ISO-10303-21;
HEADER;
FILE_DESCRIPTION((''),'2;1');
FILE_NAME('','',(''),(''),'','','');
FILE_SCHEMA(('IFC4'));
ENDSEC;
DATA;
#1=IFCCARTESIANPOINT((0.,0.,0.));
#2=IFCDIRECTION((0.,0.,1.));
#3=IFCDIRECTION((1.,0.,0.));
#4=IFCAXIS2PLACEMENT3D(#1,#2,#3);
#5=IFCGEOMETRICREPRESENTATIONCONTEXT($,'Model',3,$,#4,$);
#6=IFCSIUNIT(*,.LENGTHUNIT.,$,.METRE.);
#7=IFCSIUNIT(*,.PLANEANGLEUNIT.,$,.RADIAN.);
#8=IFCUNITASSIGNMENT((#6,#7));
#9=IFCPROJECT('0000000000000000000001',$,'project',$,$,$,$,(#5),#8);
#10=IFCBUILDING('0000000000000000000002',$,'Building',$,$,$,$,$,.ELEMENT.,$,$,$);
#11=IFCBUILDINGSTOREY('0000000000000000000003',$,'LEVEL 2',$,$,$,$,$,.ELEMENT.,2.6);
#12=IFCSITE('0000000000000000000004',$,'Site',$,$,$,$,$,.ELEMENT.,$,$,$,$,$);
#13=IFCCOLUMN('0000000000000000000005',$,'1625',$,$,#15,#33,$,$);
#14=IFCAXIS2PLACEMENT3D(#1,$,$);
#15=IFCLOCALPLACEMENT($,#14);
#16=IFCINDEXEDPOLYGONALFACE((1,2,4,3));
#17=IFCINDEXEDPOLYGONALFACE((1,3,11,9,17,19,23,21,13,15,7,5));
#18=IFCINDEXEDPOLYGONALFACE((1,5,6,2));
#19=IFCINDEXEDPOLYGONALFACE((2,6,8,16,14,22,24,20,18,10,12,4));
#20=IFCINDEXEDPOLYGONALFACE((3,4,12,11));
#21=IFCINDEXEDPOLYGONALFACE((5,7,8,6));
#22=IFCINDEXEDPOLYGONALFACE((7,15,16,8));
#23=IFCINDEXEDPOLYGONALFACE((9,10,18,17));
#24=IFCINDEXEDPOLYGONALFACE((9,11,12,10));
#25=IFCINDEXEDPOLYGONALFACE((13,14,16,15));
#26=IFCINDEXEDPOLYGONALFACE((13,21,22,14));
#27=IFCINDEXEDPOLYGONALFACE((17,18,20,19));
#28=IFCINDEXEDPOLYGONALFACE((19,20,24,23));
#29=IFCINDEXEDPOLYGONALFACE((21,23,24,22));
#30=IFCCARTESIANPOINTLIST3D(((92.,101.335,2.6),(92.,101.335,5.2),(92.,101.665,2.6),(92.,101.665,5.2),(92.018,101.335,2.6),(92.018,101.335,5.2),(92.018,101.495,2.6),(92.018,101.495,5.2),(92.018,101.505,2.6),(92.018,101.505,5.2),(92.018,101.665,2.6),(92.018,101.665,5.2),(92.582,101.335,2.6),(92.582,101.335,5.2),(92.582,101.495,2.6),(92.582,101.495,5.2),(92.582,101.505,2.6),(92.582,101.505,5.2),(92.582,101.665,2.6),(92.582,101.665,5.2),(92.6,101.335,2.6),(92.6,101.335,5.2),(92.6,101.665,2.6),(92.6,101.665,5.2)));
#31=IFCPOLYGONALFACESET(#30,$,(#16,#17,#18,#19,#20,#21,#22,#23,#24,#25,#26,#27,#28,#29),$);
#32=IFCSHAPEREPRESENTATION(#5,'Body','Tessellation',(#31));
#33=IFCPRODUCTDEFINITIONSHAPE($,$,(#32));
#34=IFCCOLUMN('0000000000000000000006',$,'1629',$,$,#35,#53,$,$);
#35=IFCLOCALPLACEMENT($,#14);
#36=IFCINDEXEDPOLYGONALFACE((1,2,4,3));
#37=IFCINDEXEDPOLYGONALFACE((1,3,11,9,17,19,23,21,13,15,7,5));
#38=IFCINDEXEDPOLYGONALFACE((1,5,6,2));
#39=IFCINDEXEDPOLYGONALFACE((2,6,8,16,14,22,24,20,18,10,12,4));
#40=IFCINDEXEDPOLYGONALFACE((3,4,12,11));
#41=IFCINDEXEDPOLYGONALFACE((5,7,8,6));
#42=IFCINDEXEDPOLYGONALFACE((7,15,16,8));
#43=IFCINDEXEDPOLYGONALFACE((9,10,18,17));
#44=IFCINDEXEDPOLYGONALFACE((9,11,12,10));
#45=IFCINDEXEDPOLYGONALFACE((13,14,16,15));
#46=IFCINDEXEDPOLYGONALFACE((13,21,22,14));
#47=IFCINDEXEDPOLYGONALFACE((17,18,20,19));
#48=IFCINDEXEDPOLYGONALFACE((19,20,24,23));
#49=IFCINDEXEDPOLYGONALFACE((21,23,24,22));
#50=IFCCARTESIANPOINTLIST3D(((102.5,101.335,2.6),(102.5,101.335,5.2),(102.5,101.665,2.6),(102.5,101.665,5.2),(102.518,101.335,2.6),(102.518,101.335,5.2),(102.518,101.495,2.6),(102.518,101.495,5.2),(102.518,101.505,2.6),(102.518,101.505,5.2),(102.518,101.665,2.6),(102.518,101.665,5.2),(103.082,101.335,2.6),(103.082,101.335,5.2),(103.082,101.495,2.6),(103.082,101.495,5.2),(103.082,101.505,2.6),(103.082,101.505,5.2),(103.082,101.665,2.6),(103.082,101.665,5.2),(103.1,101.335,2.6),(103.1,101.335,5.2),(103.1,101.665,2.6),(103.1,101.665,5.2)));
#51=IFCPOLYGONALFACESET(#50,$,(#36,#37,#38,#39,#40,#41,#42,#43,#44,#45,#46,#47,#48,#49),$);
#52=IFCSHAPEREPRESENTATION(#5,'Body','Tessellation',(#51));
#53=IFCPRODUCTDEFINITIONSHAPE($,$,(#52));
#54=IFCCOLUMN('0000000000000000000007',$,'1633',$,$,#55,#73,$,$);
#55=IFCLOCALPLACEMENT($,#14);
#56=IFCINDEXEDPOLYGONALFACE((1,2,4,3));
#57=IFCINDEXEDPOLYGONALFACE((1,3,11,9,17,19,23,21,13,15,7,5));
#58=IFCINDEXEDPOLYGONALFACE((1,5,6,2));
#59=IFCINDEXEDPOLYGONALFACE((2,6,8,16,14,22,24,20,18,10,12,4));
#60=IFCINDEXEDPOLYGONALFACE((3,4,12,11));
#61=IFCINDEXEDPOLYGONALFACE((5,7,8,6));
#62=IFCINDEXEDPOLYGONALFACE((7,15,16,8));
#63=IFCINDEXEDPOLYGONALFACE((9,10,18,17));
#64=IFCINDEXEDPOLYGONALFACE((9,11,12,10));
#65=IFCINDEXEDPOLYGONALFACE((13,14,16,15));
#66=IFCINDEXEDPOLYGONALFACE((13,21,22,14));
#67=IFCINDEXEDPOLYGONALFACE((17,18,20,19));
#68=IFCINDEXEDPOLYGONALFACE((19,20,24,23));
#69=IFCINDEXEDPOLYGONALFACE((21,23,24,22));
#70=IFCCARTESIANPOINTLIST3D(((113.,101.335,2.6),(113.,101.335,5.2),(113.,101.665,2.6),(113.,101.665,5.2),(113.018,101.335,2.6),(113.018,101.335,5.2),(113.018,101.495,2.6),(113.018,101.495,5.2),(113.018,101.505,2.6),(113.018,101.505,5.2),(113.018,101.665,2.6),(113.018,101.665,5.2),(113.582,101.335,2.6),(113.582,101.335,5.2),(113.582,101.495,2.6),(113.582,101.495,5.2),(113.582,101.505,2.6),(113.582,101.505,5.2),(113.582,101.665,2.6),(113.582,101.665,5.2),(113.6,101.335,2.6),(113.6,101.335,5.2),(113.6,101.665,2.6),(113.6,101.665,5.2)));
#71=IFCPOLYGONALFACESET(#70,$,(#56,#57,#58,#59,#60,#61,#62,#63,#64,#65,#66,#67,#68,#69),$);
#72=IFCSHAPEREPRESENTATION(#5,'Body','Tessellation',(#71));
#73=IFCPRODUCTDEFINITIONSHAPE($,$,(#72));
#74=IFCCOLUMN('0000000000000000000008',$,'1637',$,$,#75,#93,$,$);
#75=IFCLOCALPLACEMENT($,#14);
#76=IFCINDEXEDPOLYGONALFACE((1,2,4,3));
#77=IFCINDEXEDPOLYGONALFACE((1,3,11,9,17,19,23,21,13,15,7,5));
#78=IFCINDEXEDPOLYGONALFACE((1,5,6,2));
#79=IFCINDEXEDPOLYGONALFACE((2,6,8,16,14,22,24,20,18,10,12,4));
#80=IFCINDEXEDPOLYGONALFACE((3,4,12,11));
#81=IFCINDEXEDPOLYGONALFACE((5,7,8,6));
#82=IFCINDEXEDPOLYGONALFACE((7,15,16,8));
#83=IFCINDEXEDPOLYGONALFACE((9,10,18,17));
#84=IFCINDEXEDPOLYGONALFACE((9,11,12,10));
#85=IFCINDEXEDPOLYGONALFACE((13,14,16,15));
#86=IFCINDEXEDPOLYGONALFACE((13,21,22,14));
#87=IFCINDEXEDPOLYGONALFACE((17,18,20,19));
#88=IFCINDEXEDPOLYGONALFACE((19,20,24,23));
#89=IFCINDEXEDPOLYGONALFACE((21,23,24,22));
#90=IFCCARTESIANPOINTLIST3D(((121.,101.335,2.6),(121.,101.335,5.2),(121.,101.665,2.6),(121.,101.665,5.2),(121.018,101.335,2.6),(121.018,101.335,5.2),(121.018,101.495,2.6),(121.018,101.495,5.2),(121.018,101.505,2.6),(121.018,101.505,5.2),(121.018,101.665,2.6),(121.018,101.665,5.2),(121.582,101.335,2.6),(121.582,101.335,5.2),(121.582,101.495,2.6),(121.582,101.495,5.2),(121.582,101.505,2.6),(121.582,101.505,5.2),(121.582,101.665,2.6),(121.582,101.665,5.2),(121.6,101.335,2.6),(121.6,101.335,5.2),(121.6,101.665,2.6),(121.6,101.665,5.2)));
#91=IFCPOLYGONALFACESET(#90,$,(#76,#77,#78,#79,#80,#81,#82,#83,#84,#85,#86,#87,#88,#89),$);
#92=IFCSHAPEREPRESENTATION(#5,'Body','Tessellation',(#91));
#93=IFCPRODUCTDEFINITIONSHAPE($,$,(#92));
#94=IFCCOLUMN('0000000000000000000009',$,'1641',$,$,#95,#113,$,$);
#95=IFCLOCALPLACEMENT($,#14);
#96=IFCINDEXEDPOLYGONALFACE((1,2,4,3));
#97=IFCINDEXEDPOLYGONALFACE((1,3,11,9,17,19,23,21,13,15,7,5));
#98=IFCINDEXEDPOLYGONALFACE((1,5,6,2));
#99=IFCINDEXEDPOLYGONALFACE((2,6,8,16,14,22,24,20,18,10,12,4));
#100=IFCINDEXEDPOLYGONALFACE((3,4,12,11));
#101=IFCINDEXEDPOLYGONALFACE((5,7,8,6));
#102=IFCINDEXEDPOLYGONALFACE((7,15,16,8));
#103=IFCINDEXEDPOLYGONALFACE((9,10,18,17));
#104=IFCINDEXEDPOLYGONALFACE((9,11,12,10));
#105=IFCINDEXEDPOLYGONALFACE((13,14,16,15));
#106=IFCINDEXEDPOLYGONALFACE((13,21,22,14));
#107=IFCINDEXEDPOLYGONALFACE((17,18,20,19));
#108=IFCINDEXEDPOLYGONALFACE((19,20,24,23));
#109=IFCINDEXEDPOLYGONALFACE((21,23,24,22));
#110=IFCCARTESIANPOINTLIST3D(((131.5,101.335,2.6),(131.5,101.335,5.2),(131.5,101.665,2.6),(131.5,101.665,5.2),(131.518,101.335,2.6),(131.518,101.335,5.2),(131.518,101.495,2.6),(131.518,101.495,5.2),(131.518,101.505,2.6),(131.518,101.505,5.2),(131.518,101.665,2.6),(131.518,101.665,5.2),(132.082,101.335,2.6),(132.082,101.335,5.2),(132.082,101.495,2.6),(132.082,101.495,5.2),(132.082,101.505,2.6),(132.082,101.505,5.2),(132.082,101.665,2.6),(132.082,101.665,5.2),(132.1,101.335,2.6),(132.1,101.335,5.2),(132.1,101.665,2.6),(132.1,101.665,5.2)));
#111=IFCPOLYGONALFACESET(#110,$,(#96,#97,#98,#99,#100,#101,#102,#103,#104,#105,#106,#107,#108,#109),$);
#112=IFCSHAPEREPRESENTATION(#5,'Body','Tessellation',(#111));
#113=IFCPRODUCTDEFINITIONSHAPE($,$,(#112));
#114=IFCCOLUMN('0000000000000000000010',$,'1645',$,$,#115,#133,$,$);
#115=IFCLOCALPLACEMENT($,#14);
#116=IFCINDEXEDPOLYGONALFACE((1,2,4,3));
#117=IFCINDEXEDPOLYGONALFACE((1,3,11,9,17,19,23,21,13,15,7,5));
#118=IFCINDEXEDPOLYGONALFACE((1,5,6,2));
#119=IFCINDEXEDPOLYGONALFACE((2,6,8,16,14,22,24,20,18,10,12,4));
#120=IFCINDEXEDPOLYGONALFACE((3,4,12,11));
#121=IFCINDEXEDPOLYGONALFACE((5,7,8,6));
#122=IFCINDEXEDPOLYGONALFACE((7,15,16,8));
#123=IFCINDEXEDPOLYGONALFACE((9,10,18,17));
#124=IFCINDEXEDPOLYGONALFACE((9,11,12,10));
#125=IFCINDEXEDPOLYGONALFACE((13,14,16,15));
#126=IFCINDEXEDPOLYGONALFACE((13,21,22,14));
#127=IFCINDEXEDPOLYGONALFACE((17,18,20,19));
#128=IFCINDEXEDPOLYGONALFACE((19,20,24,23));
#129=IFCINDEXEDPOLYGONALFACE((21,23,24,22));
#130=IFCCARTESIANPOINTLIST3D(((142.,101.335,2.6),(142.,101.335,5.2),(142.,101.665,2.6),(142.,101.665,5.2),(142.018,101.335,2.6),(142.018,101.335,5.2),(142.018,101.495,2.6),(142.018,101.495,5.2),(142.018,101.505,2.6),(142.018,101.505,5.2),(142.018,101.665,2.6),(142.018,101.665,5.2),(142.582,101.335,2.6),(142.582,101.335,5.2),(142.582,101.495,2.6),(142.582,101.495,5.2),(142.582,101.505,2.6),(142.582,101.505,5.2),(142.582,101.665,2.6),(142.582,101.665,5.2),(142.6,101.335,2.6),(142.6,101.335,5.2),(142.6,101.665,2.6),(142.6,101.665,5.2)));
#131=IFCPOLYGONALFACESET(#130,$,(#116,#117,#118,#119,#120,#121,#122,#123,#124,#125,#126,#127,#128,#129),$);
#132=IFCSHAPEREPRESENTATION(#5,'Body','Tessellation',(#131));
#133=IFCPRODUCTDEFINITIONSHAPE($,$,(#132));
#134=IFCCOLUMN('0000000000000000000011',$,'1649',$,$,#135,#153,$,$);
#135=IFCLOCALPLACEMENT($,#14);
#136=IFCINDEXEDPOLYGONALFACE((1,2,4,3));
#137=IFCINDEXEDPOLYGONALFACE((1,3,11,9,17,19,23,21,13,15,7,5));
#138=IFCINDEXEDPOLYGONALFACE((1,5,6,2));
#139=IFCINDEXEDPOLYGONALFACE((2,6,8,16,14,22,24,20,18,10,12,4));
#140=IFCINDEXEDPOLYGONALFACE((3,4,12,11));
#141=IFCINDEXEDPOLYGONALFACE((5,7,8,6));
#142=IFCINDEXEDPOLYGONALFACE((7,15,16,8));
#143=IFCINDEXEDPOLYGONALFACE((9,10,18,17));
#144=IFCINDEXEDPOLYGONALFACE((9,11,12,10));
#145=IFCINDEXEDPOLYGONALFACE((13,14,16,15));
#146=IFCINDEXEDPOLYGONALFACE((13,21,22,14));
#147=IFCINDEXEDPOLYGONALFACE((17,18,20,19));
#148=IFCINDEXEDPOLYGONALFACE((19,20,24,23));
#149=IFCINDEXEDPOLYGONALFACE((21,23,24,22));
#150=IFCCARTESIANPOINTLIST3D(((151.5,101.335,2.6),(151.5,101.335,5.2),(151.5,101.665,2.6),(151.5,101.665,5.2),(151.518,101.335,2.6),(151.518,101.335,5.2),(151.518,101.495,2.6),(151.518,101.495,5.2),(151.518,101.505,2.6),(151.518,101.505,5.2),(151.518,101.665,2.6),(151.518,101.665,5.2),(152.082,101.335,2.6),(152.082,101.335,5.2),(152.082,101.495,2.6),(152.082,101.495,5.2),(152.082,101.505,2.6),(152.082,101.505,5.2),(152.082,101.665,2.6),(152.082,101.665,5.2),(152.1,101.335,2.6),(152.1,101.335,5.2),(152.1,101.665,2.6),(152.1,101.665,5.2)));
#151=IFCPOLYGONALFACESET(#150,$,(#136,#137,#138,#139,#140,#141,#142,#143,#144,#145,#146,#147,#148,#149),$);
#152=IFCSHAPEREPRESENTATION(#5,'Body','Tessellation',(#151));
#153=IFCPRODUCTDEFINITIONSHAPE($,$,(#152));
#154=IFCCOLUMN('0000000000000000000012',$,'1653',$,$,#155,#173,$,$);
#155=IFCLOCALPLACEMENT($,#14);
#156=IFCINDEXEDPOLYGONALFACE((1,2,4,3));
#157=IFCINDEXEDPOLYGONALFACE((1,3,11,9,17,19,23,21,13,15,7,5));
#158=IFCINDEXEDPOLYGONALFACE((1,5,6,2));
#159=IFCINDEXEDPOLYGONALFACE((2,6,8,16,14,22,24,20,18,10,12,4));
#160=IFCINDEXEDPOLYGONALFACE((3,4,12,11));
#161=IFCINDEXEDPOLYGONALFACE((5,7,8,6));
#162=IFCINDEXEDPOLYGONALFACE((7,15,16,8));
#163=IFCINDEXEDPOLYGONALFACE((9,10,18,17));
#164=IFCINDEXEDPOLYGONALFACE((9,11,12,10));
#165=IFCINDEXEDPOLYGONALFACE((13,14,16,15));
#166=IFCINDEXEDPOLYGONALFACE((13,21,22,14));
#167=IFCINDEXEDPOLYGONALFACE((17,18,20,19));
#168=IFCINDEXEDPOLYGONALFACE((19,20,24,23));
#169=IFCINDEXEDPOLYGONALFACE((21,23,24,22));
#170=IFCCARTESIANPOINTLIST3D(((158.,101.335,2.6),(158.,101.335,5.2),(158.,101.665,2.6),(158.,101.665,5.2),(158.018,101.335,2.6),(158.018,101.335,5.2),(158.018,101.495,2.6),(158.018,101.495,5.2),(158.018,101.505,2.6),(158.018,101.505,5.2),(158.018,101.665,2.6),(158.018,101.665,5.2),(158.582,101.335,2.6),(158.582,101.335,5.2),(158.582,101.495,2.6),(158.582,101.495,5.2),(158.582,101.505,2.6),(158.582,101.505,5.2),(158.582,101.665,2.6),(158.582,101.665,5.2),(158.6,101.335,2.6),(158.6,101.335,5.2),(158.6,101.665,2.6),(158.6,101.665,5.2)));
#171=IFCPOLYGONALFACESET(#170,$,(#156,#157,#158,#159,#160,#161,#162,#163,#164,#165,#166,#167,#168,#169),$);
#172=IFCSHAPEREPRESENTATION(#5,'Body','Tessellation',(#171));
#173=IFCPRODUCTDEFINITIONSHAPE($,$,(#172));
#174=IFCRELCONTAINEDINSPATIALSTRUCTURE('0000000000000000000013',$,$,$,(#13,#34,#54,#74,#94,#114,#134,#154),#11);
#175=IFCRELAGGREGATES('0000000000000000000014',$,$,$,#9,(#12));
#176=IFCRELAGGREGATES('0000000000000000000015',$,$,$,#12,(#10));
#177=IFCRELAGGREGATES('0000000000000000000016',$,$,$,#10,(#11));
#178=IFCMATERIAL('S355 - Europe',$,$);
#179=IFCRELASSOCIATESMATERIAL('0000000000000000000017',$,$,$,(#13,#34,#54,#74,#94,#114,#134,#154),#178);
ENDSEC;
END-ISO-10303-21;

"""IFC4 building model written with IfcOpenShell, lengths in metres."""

from ifc_helpers import new_model, si_unit, frame, origin_with_axes, origin_2d_with_axis, place, context, project, spatial, i_section, extrude, material, material_profile, profile_set, profile_usage, element, save


model = new_model("IFC4")

# Units and contexts
model_context = context("Model", 3, world=origin_with_axes())
ifc_project = project(units=[si_unit("LENGTHUNIT", "METRE"), si_unit("PLANEANGLEUNIT", "RADIAN")], contexts=[model_context])

# Site, building, storey
site = spatial("IfcSite", under=ifc_project, Name="Site", CompositionType="ELEMENT")
building = spatial("IfcBuilding", under=site, Name="Building", CompositionType="ELEMENT")
storey = spatial("IfcBuildingStorey", under=building, Name="LEVEL 2", CompositionType="ELEMENT", Elevation=2.6)

# Columns
ifc_material = material(Name="S355 - Europe")
ifc_material_profile_1 = material_profile(ifc_material, i_section(OverallWidth=0.33, OverallDepth=0.6, WebThickness=0.01, FlangeThickness=0.018, at=origin_2d_with_axis()))
ifc_profile_set_1 = profile_set([ifc_material_profile_1])
ifc_profile_usage_1 = profile_usage(ifc_profile_set_1, cardinal=10)
column_1_placement = place(None, frame((92.3, 101.5, 2.6), z_axis=(0.0, 0.0, 1.0), x_axis=(0.0, -1.0, 0.0)))
element("IfcColumn", 1, at=column_1_placement, inside=storey, material=ifc_profile_usage_1, Name="1625", context=model_context, shape_type="SweptSolid", body=[
    extrude(i_section(OverallWidth=0.33, OverallDepth=0.6, WebThickness=0.01, FlangeThickness=0.018, at=origin_2d_with_axis()), origin_with_axes(), (0.0, 0.0, 1.0), 2.6),
])
ifc_material_profile_2 = material_profile(ifc_material, i_section(OverallWidth=0.33, OverallDepth=0.6, WebThickness=0.01, FlangeThickness=0.018, at=origin_2d_with_axis()))
ifc_profile_set_2 = profile_set([ifc_material_profile_2])
ifc_profile_usage_2 = profile_usage(ifc_profile_set_2, cardinal=10)
column_2_placement = place(None, frame((102.8, 101.5, 2.6), z_axis=(0.0, 0.0, 1.0), x_axis=(0.0, -1.0, 0.0)))
element("IfcColumn", 2, at=column_2_placement, inside=storey, material=ifc_profile_usage_2, Name="1629", context=model_context, shape_type="SweptSolid", body=[
    extrude(i_section(OverallWidth=0.33, OverallDepth=0.6, WebThickness=0.01, FlangeThickness=0.018, at=origin_2d_with_axis()), origin_with_axes(), (0.0, 0.0, 1.0), 2.6),
])
ifc_material_profile_3 = material_profile(ifc_material, i_section(OverallWidth=0.33, OverallDepth=0.6, WebThickness=0.01, FlangeThickness=0.018, at=origin_2d_with_axis()))
ifc_profile_set_3 = profile_set([ifc_material_profile_3])
ifc_profile_usage_3 = profile_usage(ifc_profile_set_3, cardinal=10)
column_3_placement = place(None, frame((113.3, 101.5, 2.6), z_axis=(0.0, 0.0, 1.0), x_axis=(0.0, -1.0, 0.0)))
element("IfcColumn", 3, at=column_3_placement, inside=storey, material=ifc_profile_usage_3, Name="1633", context=model_context, shape_type="SweptSolid", body=[
    extrude(i_section(OverallWidth=0.33, OverallDepth=0.6, WebThickness=0.01, FlangeThickness=0.018, at=origin_2d_with_axis()), origin_with_axes(), (0.0, 0.0, 1.0), 2.6),
])
ifc_material_profile_4 = material_profile(ifc_material, i_section(OverallWidth=0.33, OverallDepth=0.6, WebThickness=0.01, FlangeThickness=0.018, at=origin_2d_with_axis()))
ifc_profile_set_4 = profile_set([ifc_material_profile_4])
ifc_profile_usage_4 = profile_usage(ifc_profile_set_4, cardinal=10)
column_4_placement = place(None, frame((121.3, 101.5, 2.6), z_axis=(0.0, 0.0, 1.0), x_axis=(0.0, -1.0, 0.0)))
element("IfcColumn", 4, at=column_4_placement, inside=storey, material=ifc_profile_usage_4, Name="1637", context=model_context, shape_type="SweptSolid", body=[
    extrude(i_section(OverallWidth=0.33, OverallDepth=0.6, WebThickness=0.01, FlangeThickness=0.018, at=origin_2d_with_axis()), origin_with_axes(), (0.0, 0.0, 1.0), 2.6),
])
ifc_material_profile_5 = material_profile(ifc_material, i_section(OverallWidth=0.33, OverallDepth=0.6, WebThickness=0.01, FlangeThickness=0.018, at=origin_2d_with_axis()))
ifc_profile_set_5 = profile_set([ifc_material_profile_5])
ifc_profile_usage_5 = profile_usage(ifc_profile_set_5, cardinal=10)
column_5_placement = place(None, frame((131.8, 101.5, 2.6), z_axis=(0.0, 0.0, 1.0), x_axis=(0.0, -1.0, 0.0)))
element("IfcColumn", 5, at=column_5_placement, inside=storey, material=ifc_profile_usage_5, Name="1641", context=model_context, shape_type="SweptSolid", body=[
    extrude(i_section(OverallWidth=0.33, OverallDepth=0.6, WebThickness=0.01, FlangeThickness=0.018, at=origin_2d_with_axis()), origin_with_axes(), (0.0, 0.0, 1.0), 2.6),
])
ifc_material_profile_6 = material_profile(ifc_material, i_section(OverallWidth=0.33, OverallDepth=0.6, WebThickness=0.01, FlangeThickness=0.018, at=origin_2d_with_axis()))
ifc_profile_set_6 = profile_set([ifc_material_profile_6])
ifc_profile_usage_6 = profile_usage(ifc_profile_set_6, cardinal=10)
column_6_placement = place(None, frame((142.3, 101.5, 2.6), z_axis=(0.0, 0.0, 1.0), x_axis=(0.0, -1.0, 0.0)))
element("IfcColumn", 6, at=column_6_placement, inside=storey, material=ifc_profile_usage_6, Name="1645", context=model_context, shape_type="SweptSolid", body=[
    extrude(i_section(OverallWidth=0.33, OverallDepth=0.6, WebThickness=0.01, FlangeThickness=0.018, at=origin_2d_with_axis()), origin_with_axes(), (0.0, 0.0, 1.0), 2.6),
])
ifc_material_profile_7 = material_profile(ifc_material, i_section(OverallWidth=0.33, OverallDepth=0.6, WebThickness=0.01, FlangeThickness=0.018, at=origin_2d_with_axis()))
ifc_profile_set_7 = profile_set([ifc_material_profile_7])
ifc_profile_usage_7 = profile_usage(ifc_profile_set_7, cardinal=10)
column_7_placement = place(None, frame((151.8, 101.5, 2.6), z_axis=(0.0, 0.0, 1.0), x_axis=(0.0, -1.0, 0.0)))
element("IfcColumn", 7, at=column_7_placement, inside=storey, material=ifc_profile_usage_7, Name="1649", context=model_context, shape_type="SweptSolid", body=[
    extrude(i_section(OverallWidth=0.33, OverallDepth=0.6, WebThickness=0.01, FlangeThickness=0.018, at=origin_2d_with_axis()), origin_with_axes(), (0.0, 0.0, 1.0), 2.6),
])
ifc_material_profile_8 = material_profile(ifc_material, i_section(OverallWidth=0.33, OverallDepth=0.6, WebThickness=0.01, FlangeThickness=0.018, at=origin_2d_with_axis()))
ifc_profile_set_8 = profile_set([ifc_material_profile_8])
ifc_profile_usage_8 = profile_usage(ifc_profile_set_8, cardinal=10)
column_8_placement = place(None, frame((158.3, 101.5, 2.6), z_axis=(0.0, 0.0, 1.0), x_axis=(0.0, -1.0, 0.0)))
element("IfcColumn", 8, at=column_8_placement, inside=storey, material=ifc_profile_usage_8, Name="1653", context=model_context, shape_type="SweptSolid", body=[
    extrude(i_section(OverallWidth=0.33, OverallDepth=0.6, WebThickness=0.01, FlangeThickness=0.018, at=origin_2d_with_axis()), origin_with_axes(), (0.0, 0.0, 1.0), 2.6),
])

save(model, "model.ifc")
